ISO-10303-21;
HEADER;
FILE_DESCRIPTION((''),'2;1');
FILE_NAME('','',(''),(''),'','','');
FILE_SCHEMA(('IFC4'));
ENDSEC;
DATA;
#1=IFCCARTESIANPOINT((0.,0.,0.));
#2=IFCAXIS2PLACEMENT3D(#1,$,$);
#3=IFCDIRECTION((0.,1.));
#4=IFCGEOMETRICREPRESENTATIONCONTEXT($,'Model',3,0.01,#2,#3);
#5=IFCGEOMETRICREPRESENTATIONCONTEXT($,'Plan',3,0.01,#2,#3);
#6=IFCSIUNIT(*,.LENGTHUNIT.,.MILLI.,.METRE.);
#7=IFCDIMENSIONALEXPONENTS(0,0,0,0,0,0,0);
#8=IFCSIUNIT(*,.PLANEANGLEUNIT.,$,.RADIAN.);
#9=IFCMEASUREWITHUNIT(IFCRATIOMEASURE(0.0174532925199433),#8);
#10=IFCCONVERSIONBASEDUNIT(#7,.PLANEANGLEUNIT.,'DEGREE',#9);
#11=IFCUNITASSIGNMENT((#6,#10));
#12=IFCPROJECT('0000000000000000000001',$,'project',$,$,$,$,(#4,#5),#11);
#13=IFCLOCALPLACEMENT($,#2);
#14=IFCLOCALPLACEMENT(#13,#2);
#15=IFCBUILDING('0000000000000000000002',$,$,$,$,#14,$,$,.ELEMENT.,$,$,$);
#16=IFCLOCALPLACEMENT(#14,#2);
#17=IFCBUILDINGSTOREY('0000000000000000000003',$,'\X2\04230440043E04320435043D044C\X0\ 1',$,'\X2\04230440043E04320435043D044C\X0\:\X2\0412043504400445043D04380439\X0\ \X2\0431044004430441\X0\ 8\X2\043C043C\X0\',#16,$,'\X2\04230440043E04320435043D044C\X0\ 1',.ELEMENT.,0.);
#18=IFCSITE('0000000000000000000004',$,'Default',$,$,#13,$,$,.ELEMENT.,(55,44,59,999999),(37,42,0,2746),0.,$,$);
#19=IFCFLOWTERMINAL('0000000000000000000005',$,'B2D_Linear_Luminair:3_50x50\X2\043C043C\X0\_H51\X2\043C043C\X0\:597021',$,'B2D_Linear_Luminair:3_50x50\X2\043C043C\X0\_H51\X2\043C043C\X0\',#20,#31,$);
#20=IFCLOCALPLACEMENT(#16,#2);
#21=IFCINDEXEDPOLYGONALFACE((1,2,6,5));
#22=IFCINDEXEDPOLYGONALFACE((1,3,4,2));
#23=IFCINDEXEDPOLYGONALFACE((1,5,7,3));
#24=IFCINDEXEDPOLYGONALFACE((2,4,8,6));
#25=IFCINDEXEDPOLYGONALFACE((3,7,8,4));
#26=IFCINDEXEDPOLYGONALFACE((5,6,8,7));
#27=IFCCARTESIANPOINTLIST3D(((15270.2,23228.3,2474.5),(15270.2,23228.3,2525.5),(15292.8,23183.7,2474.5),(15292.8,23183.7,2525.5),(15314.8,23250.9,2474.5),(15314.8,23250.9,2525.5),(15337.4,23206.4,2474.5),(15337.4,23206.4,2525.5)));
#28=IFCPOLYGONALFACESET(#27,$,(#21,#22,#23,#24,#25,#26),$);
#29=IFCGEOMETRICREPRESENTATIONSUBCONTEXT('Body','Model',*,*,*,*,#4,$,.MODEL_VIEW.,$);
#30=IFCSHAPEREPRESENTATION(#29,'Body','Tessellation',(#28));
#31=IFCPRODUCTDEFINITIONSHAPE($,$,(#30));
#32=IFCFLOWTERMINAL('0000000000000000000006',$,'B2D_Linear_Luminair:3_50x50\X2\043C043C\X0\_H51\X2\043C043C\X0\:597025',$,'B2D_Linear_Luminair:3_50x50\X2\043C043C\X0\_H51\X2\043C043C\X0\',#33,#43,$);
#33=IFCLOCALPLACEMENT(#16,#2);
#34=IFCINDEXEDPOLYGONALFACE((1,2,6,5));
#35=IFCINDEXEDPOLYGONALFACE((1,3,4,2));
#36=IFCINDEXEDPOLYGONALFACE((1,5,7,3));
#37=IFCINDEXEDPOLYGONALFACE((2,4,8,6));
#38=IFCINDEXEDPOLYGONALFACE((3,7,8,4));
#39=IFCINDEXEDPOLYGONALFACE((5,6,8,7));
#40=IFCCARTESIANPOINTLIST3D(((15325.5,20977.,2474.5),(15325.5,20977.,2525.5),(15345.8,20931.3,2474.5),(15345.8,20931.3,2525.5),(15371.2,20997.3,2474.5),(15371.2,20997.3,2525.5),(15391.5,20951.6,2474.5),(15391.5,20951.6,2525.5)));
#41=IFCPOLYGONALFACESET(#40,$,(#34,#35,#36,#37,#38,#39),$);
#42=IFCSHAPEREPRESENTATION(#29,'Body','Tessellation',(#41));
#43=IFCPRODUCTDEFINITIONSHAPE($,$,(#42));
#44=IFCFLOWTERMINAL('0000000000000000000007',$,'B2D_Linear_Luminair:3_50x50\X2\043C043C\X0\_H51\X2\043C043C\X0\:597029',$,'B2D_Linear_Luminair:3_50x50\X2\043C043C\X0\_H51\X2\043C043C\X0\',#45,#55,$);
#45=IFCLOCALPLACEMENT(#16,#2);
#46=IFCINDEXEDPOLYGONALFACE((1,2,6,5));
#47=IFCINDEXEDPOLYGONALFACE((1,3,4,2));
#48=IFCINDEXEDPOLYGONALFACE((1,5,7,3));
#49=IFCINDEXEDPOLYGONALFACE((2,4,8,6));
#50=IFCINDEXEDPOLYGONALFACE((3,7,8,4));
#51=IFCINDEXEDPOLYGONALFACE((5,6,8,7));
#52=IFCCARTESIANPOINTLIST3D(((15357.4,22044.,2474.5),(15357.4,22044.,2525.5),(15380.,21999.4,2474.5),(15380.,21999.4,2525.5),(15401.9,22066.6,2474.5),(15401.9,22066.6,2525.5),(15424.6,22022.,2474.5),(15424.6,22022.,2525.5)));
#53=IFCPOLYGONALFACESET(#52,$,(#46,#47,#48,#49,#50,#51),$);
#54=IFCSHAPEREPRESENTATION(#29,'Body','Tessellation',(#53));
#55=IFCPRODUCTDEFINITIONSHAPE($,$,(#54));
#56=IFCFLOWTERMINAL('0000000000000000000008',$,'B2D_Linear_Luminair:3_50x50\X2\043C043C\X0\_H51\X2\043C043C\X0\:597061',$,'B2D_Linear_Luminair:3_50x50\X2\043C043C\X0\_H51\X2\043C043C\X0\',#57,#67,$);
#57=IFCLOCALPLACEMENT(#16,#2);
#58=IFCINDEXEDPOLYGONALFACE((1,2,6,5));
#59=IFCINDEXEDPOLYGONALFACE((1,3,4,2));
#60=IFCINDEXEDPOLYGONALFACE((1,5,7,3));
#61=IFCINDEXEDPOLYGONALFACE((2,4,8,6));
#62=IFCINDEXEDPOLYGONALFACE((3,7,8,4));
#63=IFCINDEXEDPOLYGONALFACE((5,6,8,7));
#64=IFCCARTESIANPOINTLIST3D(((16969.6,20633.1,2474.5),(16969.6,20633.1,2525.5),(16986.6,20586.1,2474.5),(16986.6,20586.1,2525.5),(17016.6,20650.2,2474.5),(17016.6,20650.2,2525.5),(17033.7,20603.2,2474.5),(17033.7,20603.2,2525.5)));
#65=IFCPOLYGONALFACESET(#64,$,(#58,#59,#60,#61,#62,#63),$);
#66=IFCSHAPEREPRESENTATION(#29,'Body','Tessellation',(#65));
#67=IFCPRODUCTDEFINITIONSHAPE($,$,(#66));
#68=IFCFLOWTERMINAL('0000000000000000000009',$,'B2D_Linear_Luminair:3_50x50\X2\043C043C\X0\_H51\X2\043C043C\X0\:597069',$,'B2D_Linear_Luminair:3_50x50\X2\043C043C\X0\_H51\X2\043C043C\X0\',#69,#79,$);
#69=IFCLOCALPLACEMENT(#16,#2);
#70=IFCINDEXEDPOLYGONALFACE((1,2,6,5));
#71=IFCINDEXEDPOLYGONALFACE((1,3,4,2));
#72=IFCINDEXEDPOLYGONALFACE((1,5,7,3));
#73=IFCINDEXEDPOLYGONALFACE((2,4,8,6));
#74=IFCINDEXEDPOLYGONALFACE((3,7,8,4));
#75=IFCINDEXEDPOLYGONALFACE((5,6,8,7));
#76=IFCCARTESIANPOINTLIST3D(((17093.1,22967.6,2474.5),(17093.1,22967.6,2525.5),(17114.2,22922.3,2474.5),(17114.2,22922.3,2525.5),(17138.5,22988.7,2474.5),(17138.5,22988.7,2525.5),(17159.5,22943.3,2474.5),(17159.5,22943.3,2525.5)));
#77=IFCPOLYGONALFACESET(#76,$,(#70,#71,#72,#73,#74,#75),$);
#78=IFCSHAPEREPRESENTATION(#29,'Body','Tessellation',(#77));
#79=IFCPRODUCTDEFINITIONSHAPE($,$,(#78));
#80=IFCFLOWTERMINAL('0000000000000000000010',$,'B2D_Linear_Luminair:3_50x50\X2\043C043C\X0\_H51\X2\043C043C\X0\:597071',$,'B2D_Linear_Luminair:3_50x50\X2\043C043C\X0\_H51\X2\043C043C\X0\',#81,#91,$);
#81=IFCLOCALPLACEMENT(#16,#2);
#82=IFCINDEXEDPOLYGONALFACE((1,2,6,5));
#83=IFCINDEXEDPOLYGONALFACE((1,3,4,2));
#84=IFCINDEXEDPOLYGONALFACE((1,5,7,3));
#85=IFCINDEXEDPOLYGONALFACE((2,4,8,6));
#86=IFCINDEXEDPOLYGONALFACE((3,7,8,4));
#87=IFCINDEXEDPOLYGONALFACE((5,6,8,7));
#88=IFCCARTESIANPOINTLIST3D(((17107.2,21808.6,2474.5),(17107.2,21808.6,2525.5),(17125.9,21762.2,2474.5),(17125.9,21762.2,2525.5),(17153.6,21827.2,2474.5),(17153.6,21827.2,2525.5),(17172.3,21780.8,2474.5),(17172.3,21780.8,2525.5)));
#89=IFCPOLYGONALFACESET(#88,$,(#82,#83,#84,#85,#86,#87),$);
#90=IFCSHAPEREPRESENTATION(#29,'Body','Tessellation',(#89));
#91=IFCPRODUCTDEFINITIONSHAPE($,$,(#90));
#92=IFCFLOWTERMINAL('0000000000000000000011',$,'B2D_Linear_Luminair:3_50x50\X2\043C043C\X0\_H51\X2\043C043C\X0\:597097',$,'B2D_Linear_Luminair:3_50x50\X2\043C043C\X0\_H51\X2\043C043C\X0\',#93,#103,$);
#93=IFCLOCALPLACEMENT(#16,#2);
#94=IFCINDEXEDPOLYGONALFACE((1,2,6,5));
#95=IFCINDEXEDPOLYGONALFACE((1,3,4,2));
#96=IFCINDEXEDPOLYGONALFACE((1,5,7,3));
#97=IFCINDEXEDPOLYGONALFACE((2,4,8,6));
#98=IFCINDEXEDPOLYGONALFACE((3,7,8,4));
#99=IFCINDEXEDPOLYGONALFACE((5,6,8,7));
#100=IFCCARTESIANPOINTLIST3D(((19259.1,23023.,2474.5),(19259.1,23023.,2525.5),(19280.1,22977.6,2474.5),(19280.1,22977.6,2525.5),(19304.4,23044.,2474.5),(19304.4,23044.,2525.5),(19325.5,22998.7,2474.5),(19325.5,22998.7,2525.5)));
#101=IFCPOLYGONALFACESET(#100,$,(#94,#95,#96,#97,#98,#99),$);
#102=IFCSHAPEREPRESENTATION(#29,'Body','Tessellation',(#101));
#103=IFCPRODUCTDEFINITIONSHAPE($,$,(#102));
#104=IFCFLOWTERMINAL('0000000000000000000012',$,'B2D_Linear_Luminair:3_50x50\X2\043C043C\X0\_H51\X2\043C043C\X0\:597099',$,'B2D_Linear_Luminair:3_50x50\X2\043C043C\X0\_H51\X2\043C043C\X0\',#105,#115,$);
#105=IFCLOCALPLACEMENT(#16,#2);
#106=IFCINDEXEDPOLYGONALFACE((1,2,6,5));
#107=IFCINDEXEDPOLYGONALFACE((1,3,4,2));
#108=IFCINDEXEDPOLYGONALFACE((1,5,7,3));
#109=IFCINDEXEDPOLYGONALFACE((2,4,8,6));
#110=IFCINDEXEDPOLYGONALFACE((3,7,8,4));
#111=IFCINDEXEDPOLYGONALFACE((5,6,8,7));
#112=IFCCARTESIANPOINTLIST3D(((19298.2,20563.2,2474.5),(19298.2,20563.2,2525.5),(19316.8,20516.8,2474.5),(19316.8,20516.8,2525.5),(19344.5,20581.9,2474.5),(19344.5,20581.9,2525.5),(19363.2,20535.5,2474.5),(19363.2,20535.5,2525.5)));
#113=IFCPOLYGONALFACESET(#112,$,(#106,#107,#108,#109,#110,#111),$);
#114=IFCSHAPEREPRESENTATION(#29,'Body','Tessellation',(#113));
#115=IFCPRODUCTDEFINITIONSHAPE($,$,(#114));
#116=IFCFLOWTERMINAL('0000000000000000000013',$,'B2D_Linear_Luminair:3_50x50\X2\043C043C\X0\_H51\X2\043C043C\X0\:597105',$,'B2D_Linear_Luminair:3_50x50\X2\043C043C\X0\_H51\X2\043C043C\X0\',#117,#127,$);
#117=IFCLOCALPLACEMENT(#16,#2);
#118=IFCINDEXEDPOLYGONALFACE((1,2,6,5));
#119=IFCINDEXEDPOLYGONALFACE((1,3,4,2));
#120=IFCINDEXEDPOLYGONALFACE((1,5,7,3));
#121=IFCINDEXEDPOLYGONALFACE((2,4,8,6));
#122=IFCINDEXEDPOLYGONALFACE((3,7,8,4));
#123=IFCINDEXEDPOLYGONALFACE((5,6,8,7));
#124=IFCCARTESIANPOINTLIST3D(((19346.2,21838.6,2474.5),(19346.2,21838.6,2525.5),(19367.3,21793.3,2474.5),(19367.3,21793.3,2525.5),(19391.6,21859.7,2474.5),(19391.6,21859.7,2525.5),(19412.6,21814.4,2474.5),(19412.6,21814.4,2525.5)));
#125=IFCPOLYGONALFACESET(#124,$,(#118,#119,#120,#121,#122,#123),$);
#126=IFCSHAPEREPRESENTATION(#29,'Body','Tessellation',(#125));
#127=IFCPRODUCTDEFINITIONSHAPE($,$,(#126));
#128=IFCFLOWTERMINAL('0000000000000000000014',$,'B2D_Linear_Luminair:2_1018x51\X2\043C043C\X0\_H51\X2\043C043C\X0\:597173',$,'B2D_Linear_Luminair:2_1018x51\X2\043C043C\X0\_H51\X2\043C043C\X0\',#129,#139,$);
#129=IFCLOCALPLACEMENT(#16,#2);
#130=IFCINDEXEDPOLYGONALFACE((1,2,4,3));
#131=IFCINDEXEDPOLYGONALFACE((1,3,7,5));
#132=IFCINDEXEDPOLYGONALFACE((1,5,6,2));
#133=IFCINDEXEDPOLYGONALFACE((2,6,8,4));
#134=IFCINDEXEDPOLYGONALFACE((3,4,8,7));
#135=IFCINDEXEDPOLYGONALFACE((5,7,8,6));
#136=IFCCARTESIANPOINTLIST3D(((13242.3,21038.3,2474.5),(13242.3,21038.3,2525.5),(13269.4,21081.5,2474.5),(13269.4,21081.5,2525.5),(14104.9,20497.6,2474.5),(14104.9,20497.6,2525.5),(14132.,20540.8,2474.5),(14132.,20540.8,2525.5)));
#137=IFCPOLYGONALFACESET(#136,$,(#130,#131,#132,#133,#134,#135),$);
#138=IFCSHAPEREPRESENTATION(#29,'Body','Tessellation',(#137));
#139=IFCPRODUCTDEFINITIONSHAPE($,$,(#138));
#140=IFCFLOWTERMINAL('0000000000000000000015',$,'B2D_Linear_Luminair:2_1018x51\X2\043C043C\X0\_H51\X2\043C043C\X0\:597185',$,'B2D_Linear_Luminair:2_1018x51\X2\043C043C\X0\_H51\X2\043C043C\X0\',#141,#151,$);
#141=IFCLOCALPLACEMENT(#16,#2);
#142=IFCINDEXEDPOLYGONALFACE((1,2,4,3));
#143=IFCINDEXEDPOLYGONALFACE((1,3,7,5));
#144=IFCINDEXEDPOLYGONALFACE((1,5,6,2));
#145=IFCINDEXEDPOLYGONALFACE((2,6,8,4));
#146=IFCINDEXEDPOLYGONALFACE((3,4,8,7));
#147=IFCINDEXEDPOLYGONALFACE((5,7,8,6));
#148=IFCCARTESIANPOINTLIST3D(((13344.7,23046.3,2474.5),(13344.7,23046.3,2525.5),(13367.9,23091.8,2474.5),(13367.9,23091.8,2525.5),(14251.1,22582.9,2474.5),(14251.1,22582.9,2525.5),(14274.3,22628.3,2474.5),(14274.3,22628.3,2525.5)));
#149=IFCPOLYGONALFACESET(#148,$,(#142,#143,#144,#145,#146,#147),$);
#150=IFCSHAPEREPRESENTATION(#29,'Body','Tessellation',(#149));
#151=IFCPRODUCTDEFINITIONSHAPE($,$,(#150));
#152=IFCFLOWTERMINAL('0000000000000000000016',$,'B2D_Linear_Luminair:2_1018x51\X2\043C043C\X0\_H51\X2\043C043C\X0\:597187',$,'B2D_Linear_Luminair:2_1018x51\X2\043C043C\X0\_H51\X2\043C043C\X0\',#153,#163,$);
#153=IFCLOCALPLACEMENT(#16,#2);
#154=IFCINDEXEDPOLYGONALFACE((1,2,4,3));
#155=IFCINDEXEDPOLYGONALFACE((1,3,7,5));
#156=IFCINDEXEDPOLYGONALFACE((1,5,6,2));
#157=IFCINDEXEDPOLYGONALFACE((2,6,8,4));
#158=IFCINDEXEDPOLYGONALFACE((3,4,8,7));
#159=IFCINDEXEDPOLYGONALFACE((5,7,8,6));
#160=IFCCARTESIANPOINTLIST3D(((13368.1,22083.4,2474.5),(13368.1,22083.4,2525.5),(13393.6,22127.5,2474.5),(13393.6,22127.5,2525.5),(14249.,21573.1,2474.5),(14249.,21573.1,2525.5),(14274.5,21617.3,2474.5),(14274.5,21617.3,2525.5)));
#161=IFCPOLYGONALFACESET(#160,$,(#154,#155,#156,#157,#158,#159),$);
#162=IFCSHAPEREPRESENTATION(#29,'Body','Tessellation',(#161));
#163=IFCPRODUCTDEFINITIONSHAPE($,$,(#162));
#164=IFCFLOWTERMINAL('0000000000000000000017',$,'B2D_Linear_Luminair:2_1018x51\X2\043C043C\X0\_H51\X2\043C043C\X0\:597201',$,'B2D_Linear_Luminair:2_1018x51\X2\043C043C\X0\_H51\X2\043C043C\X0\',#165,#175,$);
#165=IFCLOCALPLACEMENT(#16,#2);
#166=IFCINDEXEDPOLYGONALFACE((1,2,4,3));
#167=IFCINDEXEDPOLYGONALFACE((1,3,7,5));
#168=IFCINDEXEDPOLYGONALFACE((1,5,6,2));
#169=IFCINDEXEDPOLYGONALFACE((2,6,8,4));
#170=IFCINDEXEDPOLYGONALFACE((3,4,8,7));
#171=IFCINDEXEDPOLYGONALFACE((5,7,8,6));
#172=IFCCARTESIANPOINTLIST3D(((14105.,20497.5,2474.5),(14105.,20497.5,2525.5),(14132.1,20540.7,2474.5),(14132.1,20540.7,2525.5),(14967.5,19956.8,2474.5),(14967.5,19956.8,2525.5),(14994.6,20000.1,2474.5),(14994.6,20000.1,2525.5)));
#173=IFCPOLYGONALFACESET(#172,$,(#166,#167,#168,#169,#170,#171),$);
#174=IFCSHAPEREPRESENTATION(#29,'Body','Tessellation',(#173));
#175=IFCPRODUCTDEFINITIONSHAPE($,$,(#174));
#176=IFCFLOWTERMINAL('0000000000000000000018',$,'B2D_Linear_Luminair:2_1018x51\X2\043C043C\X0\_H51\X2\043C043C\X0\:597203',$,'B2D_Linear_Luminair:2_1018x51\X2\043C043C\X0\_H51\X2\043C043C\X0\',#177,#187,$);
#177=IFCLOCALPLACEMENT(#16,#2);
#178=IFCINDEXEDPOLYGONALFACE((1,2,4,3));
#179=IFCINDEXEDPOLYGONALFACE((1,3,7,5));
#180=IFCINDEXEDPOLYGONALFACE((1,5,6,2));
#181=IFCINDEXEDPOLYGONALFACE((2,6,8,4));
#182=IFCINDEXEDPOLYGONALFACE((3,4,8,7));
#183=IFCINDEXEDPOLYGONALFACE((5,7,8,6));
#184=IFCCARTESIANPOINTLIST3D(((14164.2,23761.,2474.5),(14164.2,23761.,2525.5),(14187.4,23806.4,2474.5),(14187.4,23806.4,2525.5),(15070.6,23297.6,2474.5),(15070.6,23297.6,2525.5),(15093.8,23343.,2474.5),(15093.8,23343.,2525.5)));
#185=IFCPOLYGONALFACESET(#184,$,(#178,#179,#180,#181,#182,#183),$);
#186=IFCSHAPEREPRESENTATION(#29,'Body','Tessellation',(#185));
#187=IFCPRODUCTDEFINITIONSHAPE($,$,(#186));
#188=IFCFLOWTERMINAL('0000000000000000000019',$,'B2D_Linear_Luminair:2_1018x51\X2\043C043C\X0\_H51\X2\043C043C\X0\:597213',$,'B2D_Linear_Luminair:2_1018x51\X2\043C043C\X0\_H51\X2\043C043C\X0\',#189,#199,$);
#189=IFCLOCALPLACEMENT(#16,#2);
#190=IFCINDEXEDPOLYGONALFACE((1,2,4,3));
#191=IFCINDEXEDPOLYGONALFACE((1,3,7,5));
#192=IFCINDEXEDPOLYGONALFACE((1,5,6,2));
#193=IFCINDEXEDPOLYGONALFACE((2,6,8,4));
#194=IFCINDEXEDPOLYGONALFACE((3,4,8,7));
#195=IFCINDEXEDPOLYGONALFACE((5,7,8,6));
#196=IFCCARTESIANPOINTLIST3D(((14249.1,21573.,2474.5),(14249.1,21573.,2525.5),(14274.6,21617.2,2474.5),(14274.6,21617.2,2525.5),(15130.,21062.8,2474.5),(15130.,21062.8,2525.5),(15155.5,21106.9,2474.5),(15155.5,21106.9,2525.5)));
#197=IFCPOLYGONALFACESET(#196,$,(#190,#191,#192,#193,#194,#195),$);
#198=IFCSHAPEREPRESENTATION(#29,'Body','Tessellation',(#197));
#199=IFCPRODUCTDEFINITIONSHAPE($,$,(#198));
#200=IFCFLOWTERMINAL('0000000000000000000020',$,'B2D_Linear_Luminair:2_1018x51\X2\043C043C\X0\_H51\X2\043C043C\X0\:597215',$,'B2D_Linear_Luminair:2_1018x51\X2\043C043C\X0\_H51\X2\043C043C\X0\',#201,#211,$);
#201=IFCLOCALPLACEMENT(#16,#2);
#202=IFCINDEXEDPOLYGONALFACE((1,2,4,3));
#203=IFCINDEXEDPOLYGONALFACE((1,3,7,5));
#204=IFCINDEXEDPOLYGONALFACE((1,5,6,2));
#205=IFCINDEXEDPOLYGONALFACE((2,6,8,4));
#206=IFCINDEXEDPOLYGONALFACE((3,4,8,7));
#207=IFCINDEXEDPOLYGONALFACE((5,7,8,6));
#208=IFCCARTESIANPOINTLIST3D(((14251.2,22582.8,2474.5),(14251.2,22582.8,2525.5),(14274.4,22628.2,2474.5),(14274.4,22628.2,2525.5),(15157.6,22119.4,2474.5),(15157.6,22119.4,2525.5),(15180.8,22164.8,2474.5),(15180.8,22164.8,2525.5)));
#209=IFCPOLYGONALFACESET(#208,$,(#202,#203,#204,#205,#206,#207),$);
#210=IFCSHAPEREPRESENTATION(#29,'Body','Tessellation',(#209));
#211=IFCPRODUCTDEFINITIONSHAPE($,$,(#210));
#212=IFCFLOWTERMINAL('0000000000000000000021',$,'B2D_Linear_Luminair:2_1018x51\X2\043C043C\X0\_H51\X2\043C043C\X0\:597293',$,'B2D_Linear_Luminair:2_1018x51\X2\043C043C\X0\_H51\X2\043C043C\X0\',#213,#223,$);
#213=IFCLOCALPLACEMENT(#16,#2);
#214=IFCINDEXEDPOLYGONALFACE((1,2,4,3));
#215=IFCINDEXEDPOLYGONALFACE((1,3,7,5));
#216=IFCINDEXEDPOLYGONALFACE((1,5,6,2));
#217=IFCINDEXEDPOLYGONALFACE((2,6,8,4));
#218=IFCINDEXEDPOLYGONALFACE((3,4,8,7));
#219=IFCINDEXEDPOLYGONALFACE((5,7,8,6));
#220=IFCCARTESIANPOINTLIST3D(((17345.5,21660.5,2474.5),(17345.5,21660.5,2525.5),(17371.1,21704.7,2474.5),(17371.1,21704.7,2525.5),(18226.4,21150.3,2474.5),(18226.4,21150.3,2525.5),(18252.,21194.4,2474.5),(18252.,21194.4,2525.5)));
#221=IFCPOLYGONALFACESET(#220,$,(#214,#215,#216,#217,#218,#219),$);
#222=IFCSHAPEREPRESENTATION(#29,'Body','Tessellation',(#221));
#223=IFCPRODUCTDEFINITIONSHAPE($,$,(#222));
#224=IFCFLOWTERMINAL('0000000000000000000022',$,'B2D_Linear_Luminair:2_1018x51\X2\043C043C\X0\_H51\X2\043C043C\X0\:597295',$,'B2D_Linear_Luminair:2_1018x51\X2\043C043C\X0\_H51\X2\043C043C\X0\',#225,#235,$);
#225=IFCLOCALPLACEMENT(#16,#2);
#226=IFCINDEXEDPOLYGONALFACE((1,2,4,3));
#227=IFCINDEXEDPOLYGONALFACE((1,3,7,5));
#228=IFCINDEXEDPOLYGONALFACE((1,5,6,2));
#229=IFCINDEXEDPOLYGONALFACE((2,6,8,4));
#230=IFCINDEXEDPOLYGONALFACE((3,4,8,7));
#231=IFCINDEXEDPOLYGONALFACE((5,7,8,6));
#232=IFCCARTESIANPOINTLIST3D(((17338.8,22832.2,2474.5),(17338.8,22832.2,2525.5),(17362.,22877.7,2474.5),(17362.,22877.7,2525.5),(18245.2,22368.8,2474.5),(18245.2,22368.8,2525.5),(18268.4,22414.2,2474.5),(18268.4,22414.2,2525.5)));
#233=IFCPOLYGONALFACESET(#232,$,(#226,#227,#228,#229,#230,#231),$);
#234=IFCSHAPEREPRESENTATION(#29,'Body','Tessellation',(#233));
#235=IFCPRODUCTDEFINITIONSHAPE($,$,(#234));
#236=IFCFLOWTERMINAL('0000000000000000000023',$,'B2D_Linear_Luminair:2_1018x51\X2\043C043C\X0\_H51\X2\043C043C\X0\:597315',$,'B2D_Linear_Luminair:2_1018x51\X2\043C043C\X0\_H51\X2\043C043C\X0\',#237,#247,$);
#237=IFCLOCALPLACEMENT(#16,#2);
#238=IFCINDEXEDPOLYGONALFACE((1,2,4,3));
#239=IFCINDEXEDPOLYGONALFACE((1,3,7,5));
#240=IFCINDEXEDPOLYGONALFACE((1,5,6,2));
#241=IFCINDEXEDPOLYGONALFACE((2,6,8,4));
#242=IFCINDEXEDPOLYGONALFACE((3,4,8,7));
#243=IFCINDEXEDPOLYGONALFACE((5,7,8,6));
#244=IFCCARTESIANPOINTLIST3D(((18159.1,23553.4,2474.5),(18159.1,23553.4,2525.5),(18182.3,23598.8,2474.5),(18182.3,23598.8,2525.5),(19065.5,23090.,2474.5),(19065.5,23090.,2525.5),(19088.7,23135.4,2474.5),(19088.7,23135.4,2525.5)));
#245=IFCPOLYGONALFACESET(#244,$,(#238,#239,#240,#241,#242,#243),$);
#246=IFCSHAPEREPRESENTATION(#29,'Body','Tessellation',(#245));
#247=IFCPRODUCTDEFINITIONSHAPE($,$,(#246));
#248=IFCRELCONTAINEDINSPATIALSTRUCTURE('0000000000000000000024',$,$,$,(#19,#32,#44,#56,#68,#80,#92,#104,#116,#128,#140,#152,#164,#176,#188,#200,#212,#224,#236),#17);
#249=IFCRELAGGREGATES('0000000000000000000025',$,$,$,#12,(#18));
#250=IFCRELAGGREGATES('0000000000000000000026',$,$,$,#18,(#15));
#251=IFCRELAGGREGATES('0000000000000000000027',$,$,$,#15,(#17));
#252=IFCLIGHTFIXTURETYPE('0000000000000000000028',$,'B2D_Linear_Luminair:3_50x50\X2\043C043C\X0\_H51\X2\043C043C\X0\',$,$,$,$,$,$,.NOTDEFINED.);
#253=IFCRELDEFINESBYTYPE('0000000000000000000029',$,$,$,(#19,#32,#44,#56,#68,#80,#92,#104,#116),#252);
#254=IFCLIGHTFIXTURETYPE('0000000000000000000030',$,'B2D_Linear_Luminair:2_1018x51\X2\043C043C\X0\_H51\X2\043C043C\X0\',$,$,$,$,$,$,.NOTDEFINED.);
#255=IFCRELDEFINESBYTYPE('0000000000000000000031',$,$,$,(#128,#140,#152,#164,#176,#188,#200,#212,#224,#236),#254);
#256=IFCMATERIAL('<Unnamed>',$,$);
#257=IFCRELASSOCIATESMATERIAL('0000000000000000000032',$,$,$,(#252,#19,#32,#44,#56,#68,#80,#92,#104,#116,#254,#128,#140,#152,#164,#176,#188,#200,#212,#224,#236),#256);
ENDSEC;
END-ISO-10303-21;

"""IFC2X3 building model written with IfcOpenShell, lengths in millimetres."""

from ifc_helpers import new_model, entity, si_unit, converted_unit, direction, frame, origin, origin_2d_with_axis, place, context, subcontext, project, spatial, rectangle, extrude, source, transform, mapped, material, type_object, type_shapes, element, save


model = new_model("IFC2X3")

# Units and contexts
model_context = context("Model", 3, precision=0.01, world=origin(), true_north=direction((0.0, 1.0)))
plan_context = context("Plan", 3, precision=0.01, world=origin(), true_north=direction((0.0, 1.0)))
body_context = subcontext(model_context, "Body", "Model", "MODEL_VIEW")
ifc_project = project(units=[si_unit("LENGTHUNIT", "METRE", prefix="MILLI"), converted_unit("PLANEANGLEUNIT", "DEGREE", entity("IfcRatioMeasure", 0.0174532925199433), si_unit("PLANEANGLEUNIT", "RADIAN"), dimensions=[0, 0, 0, 0, 0, 0, 0])], contexts=[model_context, plan_context])

# Site, building, storey
site_placement = place(None, origin())
site = spatial("IfcSite", under=ifc_project, at=site_placement, Name="Default", CompositionType="ELEMENT", RefLatitude=(55, 44, 59, 999999), RefLongitude=(37, 42, 0, 2746), RefElevation=0.0)
building_placement = place(site_placement, origin())
building = spatial("IfcBuilding", under=site, at=building_placement, CompositionType="ELEMENT")
storey_placement = place(building_placement, origin())
storey = spatial("IfcBuildingStorey", under=building, at=storey_placement, Name="Уровень 1", ObjectType="Уровень:Верхний брус 8мм", LongName="Уровень 1", CompositionType="ELEMENT", Elevation=0.0)

# Flow terminals
ifc_material = material(Name="<Unnamed>")
light_fixture_type_1 = type_object("IfcLightFixtureType", Name="B2D_Linear_Luminair:3_50x50мм_H51мм", PredefinedType="NOTDEFINED", material=ifc_material)
shared_shape_1 = source(origin(), body_context, "Body", "SweptSolid", [
    extrude(rectangle(XDim=50.0, YDim=50.0, at=origin_2d_with_axis()), frame((0.0, 0.0, 0.0), z_axis=(0.0, 0.0, 1.0), x_axis=(-1.0, 0.0, 0.0)), (0.0, 0.0, 1.0), 51.0),
])
type_shapes(light_fixture_type_1, [shared_shape_1])
for number, where, z_axis, x_axis, name in (
    (1, (15303.8, 23217.3, 2525.5), (0.0, 0.0, -1.0), (0.89164, 0.452746, 0.0), "B2D_Linear_Luminair:3_50x50мм_H51мм:597021"),
    (2, (15358.5, 20964.3, 2525.5), (0.0, 0.0, -1.0), (0.914112, 0.405461, 0.0), "B2D_Linear_Luminair:3_50x50мм_H51мм:597025"),
    (3, (15391.0, 22033.0, 2525.5), (0.0, 0.0, -1.0), (0.89164, 0.452746, 0.0), "B2D_Linear_Luminair:3_50x50мм_H51мм:597029"),
    (4, (17001.6, 20618.2, 2525.5), (0.0, 0.0, -1.0), (0.940169, 0.340708, 0.0), "B2D_Linear_Luminair:3_50x50мм_H51мм:597061"),
    (5, (17126.3, 22955.5, 2525.5), (0.0, 0.0, -1.0), (0.906897, 0.421352, 0.0), "B2D_Linear_Luminair:3_50x50мм_H51мм:597069"),
    (6, (17139.8, 21794.7, 2525.5), (0.0, 0.0, -1.0), (0.927706, 0.373312, 0.0), "B2D_Linear_Luminair:3_50x50мм_H51мм:597071"),
    (7, (19292.3, 23010.8, 2525.5), (0.0, 0.0, -1.0), (0.906897, 0.421352, 0.0), "B2D_Linear_Luminair:3_50x50мм_H51мм:597097"),
    (8, (19330.7, 20549.4, 2525.5), (0.0, 0.0, -1.0), (0.927706, 0.373312, 0.0), "B2D_Linear_Luminair:3_50x50мм_H51мм:597099"),
    (9, (19379.4, 21826.5, 2525.5), (0.0, 0.0, -1.0), (0.906897, 0.421352, 0.0), "B2D_Linear_Luminair:3_50x50мм_H51мм:597105"),
):
    element("IfcFlowTerminal", number, at=place(storey_placement, frame(where, z_axis=z_axis, x_axis=x_axis)), inside=storey, type_object=light_fixture_type_1, material=ifc_material, Name=name, ObjectType="B2D_Linear_Luminair:3_50x50мм_H51мм", context=body_context, shape_type="MappedRepresentation", body=[
        mapped(shared_shape_1, transform((0.0, 0.0, 0.0), scale=1.0)),
    ])
light_fixture_type_2 = type_object("IfcLightFixtureType", Name="B2D_Linear_Luminair:2_1018x51мм_H51мм", PredefinedType="NOTDEFINED", material=ifc_material)
shared_shape_2 = source(origin(), body_context, "Body", "SweptSolid", [
    extrude(rectangle(XDim=1018.0, YDim=51.0, at=origin_2d_with_axis()), frame((0.0, 0.0, 0.0), z_axis=(0.0, 0.0, 1.0), x_axis=(-1.0, 0.0, 0.0)), (0.0, 0.0, 1.0), 51.0),
])
type_shapes(light_fixture_type_2, [shared_shape_2])
for number, where, z_axis, x_axis, name in (
    (10, (13687.1, 20789.5, 2525.5), (0.0, 0.0, -1.0), (0.847307, -0.531103, 0.0), "B2D_Linear_Luminair:2_1018x51мм_H51мм:597173"),
    (11, (13809.5, 22837.3, 2525.5), (0.0, 0.0, -1.0), (0.890372, -0.455234, 0.0), "B2D_Linear_Luminair:2_1018x51мм_H51мм:597185"),
    (12, (13821.3, 21850.3, 2525.5), (0.0, 0.0, -1.0), (0.865326, -0.501209, 0.0), "B2D_Linear_Luminair:2_1018x51мм_H51мм:597187"),
    (13, (14549.8, 20248.8, 2525.5), (0.0, 0.0, -1.0), (0.847307, -0.531103, 0.0), "B2D_Linear_Luminair:2_1018x51мм_H51мм:597201"),
    (14, (14629.0, 23552.0, 2525.5), (0.0, 0.0, -1.0), (0.890372, -0.455234, 0.0), "B2D_Linear_Luminair:2_1018x51мм_H51мм:597203"),
    (15, (14702.3, 21340.0, 2525.5), (0.0, 0.0, -1.0), (0.865326, -0.501209, 0.0), "B2D_Linear_Luminair:2_1018x51мм_H51мм:597213"),
    (16, (14716.0, 22373.8, 2525.5), (0.0, 0.0, -1.0), (0.890372, -0.455234, 0.0), "B2D_Linear_Luminair:2_1018x51мм_H51мм:597215"),
    (17, (17798.8, 21427.5, 2525.5), (0.0, 0.0, -1.0), (0.865326, -0.501209, 0.0), "B2D_Linear_Luminair:2_1018x51мм_H51мм:597293"),
    (18, (17803.6, 22623.2, 2525.5), (0.0, 0.0, -1.0), (0.890372, -0.455234, 0.0), "B2D_Linear_Luminair:2_1018x51мм_H51мм:597295"),
    (19, (18623.9, 23344.4, 2525.5), (0.0, 0.0, -1.0), (0.890372, -0.455234, 0.0), "B2D_Linear_Luminair:2_1018x51мм_H51мм:597315"),
):
    element("IfcFlowTerminal", number, at=place(storey_placement, frame(where, z_axis=z_axis, x_axis=x_axis)), inside=storey, type_object=light_fixture_type_2, material=ifc_material, Name=name, ObjectType="B2D_Linear_Luminair:2_1018x51мм_H51мм", context=body_context, shape_type="MappedRepresentation", body=[
        mapped(shared_shape_2, transform((0.0, 0.0, 0.0), scale=1.0)),
    ])

save(model, "model.ifc")
